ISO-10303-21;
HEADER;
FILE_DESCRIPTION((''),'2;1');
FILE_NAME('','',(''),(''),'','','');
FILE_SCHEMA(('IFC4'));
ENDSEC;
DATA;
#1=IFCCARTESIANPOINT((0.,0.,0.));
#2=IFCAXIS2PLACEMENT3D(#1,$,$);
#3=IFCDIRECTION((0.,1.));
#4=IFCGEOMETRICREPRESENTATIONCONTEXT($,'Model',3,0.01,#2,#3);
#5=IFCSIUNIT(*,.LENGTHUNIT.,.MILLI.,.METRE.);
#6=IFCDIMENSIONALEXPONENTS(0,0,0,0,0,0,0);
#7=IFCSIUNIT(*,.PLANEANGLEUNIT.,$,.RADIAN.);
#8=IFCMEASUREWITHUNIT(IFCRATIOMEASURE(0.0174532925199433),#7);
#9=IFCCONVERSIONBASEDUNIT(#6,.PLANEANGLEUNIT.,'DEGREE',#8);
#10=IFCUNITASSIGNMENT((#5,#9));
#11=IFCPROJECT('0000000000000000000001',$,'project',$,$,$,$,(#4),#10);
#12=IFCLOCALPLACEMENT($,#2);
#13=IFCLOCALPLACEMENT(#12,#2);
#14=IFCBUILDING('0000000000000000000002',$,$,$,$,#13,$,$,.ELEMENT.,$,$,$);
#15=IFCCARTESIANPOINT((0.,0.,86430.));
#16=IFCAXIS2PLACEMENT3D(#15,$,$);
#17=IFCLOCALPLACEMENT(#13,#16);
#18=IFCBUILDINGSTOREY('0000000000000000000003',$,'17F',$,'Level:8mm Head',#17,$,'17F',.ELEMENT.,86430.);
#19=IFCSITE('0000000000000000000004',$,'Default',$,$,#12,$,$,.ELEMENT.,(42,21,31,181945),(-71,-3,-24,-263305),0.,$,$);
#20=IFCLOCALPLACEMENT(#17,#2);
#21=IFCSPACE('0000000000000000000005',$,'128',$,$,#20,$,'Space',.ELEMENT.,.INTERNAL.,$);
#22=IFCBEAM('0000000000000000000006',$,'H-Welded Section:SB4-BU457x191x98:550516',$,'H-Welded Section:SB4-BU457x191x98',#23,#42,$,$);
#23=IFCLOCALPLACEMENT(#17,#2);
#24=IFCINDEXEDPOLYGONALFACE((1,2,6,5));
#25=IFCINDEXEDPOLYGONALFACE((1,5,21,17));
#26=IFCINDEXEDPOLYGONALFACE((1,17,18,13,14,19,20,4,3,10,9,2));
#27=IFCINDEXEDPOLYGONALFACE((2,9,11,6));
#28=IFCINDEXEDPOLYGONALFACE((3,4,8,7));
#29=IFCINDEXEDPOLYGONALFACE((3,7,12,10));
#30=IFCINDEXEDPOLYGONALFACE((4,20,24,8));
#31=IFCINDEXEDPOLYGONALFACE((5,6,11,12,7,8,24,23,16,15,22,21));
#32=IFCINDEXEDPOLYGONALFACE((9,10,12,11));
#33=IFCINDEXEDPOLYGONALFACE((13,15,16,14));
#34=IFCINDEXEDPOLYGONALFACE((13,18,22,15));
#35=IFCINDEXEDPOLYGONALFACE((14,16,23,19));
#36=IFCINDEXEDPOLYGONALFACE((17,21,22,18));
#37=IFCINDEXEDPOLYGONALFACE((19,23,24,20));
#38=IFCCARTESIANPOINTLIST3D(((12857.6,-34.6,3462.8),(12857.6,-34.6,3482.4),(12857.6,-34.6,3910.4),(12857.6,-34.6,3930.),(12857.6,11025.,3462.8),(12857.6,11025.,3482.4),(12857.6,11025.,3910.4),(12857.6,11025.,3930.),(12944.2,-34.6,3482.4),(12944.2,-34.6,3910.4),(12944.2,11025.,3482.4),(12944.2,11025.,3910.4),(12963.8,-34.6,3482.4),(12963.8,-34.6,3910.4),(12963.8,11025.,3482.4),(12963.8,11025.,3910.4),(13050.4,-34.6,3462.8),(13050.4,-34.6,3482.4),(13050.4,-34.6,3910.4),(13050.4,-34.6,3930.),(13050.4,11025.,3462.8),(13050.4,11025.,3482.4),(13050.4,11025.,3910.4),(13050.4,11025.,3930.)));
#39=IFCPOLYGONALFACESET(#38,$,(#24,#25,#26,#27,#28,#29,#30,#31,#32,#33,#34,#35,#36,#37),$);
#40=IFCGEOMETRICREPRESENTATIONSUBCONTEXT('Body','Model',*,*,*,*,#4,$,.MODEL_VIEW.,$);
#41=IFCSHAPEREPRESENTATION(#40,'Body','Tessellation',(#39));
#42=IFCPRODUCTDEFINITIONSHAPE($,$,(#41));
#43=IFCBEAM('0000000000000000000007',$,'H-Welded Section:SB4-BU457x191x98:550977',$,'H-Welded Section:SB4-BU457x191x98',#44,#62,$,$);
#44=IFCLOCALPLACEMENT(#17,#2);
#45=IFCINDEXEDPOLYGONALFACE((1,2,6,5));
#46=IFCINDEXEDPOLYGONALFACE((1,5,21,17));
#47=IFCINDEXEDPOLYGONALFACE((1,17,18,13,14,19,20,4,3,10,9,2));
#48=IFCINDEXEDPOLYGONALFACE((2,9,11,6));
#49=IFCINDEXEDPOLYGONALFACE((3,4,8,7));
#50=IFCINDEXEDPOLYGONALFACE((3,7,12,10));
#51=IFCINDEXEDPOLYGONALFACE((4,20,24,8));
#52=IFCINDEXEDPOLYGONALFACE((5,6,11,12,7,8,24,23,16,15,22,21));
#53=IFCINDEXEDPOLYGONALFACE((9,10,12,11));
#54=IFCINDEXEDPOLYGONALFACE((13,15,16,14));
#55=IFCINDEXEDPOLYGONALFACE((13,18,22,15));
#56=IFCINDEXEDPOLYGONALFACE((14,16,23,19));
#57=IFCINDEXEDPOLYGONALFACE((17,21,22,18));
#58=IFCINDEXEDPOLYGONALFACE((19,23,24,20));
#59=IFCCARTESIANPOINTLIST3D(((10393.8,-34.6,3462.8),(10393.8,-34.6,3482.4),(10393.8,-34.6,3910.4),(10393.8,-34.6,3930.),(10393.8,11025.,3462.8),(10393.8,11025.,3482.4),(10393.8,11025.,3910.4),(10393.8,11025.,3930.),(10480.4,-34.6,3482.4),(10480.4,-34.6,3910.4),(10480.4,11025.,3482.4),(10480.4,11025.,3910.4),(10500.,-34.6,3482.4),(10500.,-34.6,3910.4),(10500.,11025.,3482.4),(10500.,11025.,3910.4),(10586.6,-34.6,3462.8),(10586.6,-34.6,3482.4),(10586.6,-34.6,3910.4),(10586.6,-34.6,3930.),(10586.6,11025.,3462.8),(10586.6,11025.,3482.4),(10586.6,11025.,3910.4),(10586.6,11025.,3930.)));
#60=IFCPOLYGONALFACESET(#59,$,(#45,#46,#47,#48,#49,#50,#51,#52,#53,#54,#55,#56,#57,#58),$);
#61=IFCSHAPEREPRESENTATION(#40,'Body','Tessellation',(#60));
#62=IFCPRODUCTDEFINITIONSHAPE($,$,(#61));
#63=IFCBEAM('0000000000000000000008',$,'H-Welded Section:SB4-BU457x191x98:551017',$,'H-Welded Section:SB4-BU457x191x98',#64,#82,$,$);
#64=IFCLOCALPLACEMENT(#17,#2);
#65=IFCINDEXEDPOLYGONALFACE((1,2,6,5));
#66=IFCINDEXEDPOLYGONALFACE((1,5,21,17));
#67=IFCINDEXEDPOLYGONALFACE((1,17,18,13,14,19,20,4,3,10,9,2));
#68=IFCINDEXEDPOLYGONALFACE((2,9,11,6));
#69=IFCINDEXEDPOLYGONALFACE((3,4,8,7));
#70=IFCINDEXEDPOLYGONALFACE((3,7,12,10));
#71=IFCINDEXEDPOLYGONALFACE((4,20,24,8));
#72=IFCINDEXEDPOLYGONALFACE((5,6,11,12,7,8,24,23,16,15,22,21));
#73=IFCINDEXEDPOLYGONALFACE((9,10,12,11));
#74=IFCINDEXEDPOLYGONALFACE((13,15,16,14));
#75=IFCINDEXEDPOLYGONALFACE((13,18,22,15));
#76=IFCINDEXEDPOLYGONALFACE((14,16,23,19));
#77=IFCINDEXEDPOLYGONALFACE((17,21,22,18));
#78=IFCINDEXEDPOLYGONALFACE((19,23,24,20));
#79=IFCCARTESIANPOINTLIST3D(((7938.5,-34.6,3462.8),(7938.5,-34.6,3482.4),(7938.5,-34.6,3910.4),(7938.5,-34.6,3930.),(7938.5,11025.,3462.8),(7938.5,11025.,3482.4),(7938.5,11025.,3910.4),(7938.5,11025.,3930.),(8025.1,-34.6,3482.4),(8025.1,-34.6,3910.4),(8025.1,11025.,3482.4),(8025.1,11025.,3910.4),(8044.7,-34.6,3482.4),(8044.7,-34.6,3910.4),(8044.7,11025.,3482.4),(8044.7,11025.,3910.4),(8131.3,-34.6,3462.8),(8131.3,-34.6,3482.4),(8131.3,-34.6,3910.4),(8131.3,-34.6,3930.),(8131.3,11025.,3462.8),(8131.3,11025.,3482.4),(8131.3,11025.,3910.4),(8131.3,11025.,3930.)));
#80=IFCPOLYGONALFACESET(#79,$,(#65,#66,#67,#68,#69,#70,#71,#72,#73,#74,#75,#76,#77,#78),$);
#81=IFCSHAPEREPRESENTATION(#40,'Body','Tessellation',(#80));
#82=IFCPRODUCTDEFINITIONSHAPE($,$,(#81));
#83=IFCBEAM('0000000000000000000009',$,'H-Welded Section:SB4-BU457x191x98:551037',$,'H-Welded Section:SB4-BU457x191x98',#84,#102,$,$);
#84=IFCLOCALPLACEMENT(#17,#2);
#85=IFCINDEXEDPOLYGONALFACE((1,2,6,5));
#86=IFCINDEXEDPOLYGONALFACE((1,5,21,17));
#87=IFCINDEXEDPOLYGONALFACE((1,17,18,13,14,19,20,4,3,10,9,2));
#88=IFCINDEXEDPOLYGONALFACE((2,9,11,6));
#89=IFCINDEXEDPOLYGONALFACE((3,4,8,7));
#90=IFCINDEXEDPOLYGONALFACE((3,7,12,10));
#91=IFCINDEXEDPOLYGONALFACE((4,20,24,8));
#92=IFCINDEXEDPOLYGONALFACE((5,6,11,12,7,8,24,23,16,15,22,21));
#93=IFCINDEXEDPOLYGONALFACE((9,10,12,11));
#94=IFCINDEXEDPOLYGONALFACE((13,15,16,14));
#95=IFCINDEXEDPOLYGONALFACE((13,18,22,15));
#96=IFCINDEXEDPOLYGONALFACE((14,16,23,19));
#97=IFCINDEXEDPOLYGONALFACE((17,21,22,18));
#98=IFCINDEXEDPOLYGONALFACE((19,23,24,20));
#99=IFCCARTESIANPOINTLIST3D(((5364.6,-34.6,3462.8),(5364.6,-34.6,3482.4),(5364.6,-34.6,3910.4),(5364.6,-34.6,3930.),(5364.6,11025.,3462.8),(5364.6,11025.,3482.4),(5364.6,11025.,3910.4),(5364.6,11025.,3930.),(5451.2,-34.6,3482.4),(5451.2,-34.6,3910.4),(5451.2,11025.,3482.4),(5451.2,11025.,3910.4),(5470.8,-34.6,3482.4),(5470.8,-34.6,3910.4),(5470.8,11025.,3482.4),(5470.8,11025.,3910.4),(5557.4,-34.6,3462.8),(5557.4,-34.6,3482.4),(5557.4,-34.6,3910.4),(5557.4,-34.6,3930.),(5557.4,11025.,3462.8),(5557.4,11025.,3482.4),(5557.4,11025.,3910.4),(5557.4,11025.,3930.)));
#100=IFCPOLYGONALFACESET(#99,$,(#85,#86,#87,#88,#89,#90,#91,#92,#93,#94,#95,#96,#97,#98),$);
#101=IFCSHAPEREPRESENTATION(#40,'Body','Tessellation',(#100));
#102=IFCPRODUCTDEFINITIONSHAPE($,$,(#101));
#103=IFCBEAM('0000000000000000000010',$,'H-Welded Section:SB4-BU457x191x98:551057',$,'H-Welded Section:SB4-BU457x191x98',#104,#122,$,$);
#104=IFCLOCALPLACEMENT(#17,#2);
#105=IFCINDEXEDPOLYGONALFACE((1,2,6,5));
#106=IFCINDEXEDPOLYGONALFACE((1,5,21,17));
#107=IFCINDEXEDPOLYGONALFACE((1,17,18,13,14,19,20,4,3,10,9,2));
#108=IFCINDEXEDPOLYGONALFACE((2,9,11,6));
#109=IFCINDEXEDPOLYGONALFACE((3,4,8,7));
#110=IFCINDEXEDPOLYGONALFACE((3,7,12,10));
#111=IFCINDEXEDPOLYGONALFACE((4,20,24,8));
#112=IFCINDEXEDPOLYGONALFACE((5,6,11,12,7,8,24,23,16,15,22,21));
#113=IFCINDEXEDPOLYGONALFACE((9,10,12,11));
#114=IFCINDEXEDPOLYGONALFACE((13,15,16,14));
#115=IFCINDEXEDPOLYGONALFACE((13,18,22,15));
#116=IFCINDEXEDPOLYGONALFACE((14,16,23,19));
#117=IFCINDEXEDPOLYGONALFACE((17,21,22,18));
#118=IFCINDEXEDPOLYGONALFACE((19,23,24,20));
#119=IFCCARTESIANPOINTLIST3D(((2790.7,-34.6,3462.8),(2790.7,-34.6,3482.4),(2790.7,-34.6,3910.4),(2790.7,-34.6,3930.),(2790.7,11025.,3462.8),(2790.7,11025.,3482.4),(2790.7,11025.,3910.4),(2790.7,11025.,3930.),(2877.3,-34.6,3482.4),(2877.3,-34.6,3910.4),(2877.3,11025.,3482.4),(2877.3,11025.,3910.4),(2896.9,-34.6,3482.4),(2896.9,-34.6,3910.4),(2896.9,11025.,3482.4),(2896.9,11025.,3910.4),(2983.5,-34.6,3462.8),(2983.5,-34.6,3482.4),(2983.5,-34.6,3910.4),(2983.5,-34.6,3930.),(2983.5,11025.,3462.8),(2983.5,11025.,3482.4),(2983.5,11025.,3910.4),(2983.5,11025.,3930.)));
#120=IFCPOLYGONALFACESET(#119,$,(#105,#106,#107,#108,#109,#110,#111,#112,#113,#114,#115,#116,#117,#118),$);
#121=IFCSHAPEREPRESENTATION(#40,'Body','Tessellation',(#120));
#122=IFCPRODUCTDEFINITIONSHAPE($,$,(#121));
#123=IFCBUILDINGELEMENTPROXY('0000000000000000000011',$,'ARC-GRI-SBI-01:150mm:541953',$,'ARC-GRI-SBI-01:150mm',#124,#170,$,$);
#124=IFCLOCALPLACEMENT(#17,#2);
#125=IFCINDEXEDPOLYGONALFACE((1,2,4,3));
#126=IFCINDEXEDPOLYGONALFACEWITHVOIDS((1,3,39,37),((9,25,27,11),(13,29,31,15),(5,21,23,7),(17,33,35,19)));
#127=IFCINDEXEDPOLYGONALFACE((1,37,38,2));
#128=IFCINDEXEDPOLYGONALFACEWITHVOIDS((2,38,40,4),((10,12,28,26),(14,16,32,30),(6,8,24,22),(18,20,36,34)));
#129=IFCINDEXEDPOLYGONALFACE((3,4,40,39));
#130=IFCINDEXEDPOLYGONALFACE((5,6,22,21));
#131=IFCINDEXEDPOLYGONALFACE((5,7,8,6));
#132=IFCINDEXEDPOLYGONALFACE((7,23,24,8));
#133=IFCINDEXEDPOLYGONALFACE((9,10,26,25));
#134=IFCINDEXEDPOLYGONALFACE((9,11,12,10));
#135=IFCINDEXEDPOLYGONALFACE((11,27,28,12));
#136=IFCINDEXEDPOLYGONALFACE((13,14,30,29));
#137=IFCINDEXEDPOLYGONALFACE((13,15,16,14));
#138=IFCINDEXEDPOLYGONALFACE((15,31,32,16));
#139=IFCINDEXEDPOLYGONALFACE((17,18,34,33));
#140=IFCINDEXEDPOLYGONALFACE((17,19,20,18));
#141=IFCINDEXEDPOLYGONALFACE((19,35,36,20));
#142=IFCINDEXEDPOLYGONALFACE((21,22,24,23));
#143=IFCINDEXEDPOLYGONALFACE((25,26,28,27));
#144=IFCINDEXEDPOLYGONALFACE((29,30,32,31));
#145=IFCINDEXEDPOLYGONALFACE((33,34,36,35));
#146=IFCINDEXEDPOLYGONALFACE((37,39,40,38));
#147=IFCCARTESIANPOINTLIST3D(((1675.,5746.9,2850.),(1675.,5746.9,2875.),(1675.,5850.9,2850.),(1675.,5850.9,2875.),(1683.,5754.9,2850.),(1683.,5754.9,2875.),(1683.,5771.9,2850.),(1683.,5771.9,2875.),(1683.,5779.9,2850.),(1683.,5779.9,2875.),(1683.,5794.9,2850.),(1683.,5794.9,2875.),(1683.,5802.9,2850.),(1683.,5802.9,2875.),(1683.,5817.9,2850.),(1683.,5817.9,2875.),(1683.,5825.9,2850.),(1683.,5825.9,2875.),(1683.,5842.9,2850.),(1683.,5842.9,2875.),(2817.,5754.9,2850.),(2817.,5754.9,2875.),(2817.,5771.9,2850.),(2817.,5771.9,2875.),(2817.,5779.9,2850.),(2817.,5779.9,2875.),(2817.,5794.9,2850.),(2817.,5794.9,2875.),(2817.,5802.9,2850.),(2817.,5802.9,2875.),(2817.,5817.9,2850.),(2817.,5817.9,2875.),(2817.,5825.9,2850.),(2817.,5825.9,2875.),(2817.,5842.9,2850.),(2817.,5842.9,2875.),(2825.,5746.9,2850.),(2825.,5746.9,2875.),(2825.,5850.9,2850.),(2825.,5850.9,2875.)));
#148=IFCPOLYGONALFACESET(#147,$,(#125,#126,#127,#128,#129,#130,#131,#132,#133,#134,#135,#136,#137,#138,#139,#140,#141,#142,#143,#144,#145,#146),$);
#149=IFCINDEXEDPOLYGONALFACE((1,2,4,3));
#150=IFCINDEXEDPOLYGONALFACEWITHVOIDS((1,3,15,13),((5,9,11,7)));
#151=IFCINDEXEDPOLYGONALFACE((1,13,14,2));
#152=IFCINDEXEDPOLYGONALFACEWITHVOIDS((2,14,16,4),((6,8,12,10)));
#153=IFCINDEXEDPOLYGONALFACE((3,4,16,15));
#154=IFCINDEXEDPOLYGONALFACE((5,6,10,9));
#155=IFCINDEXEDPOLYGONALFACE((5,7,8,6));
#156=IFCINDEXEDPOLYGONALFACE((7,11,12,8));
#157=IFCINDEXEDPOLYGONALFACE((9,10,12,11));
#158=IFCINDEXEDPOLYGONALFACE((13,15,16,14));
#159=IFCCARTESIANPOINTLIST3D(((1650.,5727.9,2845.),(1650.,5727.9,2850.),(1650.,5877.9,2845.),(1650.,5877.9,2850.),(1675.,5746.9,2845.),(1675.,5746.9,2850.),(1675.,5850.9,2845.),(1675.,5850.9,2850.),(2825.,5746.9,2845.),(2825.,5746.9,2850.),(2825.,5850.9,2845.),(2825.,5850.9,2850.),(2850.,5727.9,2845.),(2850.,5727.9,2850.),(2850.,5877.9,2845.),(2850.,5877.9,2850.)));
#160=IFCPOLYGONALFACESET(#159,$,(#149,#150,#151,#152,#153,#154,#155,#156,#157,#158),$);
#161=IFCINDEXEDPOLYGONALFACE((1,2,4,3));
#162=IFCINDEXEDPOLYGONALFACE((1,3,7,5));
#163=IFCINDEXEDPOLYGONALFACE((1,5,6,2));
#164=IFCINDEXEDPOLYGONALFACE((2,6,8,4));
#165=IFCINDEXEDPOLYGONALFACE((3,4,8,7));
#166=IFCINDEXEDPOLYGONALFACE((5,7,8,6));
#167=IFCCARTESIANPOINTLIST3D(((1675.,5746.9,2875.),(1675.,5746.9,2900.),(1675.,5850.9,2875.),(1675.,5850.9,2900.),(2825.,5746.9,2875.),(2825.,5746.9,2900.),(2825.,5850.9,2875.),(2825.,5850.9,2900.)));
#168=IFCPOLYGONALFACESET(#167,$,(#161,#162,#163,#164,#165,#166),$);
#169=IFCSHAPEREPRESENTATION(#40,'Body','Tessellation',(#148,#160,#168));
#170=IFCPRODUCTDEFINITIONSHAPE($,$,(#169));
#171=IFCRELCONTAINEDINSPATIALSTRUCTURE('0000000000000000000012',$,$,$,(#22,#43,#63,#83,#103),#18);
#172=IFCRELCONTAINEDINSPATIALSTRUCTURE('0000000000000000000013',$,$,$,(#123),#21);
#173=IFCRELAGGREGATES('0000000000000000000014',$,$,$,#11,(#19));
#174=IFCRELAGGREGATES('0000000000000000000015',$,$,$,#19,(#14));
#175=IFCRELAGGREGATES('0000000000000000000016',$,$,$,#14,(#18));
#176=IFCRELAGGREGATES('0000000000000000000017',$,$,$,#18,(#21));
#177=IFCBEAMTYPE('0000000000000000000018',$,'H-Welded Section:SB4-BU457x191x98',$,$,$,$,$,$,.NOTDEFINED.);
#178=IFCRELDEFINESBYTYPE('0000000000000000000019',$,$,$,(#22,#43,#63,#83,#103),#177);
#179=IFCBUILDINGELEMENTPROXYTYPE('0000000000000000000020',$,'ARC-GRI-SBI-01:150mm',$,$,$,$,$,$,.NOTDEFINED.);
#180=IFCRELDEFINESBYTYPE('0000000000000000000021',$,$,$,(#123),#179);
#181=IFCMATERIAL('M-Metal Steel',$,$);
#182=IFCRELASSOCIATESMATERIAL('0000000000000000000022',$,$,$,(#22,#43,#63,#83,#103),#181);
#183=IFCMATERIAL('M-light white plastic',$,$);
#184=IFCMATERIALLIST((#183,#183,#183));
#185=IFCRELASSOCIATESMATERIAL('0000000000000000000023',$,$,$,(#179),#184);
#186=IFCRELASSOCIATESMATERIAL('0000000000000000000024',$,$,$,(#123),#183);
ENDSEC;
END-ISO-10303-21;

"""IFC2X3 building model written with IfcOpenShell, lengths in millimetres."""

from ifc_helpers import new_model, entity, si_unit, converted_unit, direction, frame, frame_2d, origin, origin_2d_with_axis, place, context, subcontext, project, spatial, polyline, rectangle, i_section, outline, extrude, source, transform, mapped, material, material_list, type_object, type_shapes, element, save


model = new_model("IFC2X3")

# Units and contexts
model_context = context("Model", 3, precision=0.01, world=origin(), true_north=direction((0.0, 1.0)))
body_context = subcontext(model_context, "Body", "Model", "MODEL_VIEW")
ifc_project = project(units=[si_unit("LENGTHUNIT", "METRE", prefix="MILLI"), converted_unit("PLANEANGLEUNIT", "DEGREE", entity("IfcRatioMeasure", 0.0174532925199433), si_unit("PLANEANGLEUNIT", "RADIAN"), dimensions=[0, 0, 0, 0, 0, 0, 0])], contexts=[model_context])

# Site, building, storey
site_placement = place(None, origin())
site = spatial("IfcSite", under=ifc_project, at=site_placement, Name="Default", CompositionType="ELEMENT", RefLatitude=(42, 21, 31, 181945), RefLongitude=(-71, -3, -24, -263305), RefElevation=0.0)
building_placement = place(site_placement, origin())
building = spatial("IfcBuilding", under=site, at=building_placement, CompositionType="ELEMENT")
storey_placement = place(building_placement, frame((0.0, 0.0, 86430.0)))
storey = spatial("IfcBuildingStorey", under=building, at=storey_placement, Name="17F", ObjectType="Level:8mm Head", LongName="17F", CompositionType="ELEMENT", Elevation=86430.0)

# Beams
ifc_material_1 = material(Name="M-Metal Steel")
beam_type = type_object("IfcBeamType", Name="H-Welded Section:SB4-BU457x191x98", PredefinedType="NOTDEFINED")
beam_1_placement = place(storey_placement, frame((12954.0, 11025.0, 0.0), z_axis=(0.0, 0.0, 1.0), x_axis=(0.0, -1.0, 0.0)))
element("IfcBeam", 1, at=beam_1_placement, inside=storey, type_object=beam_type, material=ifc_material_1, Name="H-Welded Section:SB4-BU457x191x98:550516", ObjectType="H-Welded Section:SB4-BU457x191x98", context=body_context, shape_type="SweptSolid", body=[
    extrude(i_section(OverallWidth=192.8, OverallDepth=467.2, WebThickness=19.6, FlangeThickness=19.6, at=frame_2d((0.0, 0.0), x_axis=(0.0, 1.0))), frame((0.0, 0.0, 3696.4), z_axis=(1.0, 0.0, 0.0), x_axis=(0.0, 0.0, -1.0)), (0.0, 0.0, 1.0), 11059.6),
])
beam_2_placement = place(storey_placement, frame((10490.2, 11025.0, 0.0), z_axis=(0.0, 0.0, 1.0), x_axis=(0.0, -1.0, 0.0)))
element("IfcBeam", 2, at=beam_2_placement, inside=storey, type_object=beam_type, material=ifc_material_1, Name="H-Welded Section:SB4-BU457x191x98:550977", ObjectType="H-Welded Section:SB4-BU457x191x98", context=body_context, shape_type="SweptSolid", body=[
    extrude(i_section(OverallWidth=192.8, OverallDepth=467.2, WebThickness=19.6, FlangeThickness=19.6, at=frame_2d((0.0, 0.0), x_axis=(0.0, 1.0))), frame((0.0, 0.0, 3696.4), z_axis=(1.0, 0.0, 0.0), x_axis=(0.0, 0.0, -1.0)), (0.0, 0.0, 1.0), 11059.6),
])
beam_3_placement = place(storey_placement, frame((8034.9, 11025.0, 0.0), z_axis=(0.0, 0.0, 1.0), x_axis=(0.0, -1.0, 0.0)))
element("IfcBeam", 3, at=beam_3_placement, inside=storey, type_object=beam_type, material=ifc_material_1, Name="H-Welded Section:SB4-BU457x191x98:551017", ObjectType="H-Welded Section:SB4-BU457x191x98", context=body_context, shape_type="SweptSolid", body=[
    extrude(i_section(OverallWidth=192.8, OverallDepth=467.2, WebThickness=19.6, FlangeThickness=19.6, at=frame_2d((0.0, 0.0), x_axis=(0.0, 1.0))), frame((0.0, 0.0, 3696.4), z_axis=(1.0, 0.0, 0.0), x_axis=(0.0, 0.0, -1.0)), (0.0, 0.0, 1.0), 11059.6),
])
beam_4_placement = place(storey_placement, frame((5461.0, 11025.0, 0.0), z_axis=(0.0, 0.0, 1.0), x_axis=(0.0, -1.0, 0.0)))
element("IfcBeam", 4, at=beam_4_placement, inside=storey, type_object=beam_type, material=ifc_material_1, Name="H-Welded Section:SB4-BU457x191x98:551037", ObjectType="H-Welded Section:SB4-BU457x191x98", context=body_context, shape_type="SweptSolid", body=[
    extrude(i_section(OverallWidth=192.8, OverallDepth=467.2, WebThickness=19.6, FlangeThickness=19.6, at=frame_2d((0.0, 0.0), x_axis=(0.0, 1.0))), frame((0.0, 0.0, 3696.4), z_axis=(1.0, 0.0, 0.0), x_axis=(0.0, 0.0, -1.0)), (0.0, 0.0, 1.0), 11059.6),
])
beam_5_placement = place(storey_placement, frame((2887.1, 11025.0, 0.0), z_axis=(0.0, 0.0, 1.0), x_axis=(0.0, -1.0, 0.0)))
element("IfcBeam", 5, at=beam_5_placement, inside=storey, type_object=beam_type, material=ifc_material_1, Name="H-Welded Section:SB4-BU457x191x98:551057", ObjectType="H-Welded Section:SB4-BU457x191x98", context=body_context, shape_type="SweptSolid", body=[
    extrude(i_section(OverallWidth=192.8, OverallDepth=467.2, WebThickness=19.6, FlangeThickness=19.6, at=frame_2d((0.0, 0.0), x_axis=(0.0, 1.0))), frame((0.0, 0.0, 3696.4), z_axis=(1.0, 0.0, 0.0), x_axis=(0.0, 0.0, -1.0)), (0.0, 0.0, 1.0), 11059.6),
])

# Shared definitions
space_placement = place(storey_placement, origin())
space = spatial("IfcSpace", under=storey, at=space_placement, Name="128", LongName="Space", CompositionType="ELEMENT", InteriorOrExteriorSpace="INTERNAL")

# Building element proxy
ifc_material_2 = material(Name="M-light white plastic")
ifc_material_list = material_list([ifc_material_2, ifc_material_2, ifc_material_2])
building_element_proxy_type = type_object("IfcBuildingElementProxyType", Name="ARC-GRI-SBI-01:150mm", PredefinedType="NOTDEFINED", material=ifc_material_list)
shared_shape = source(origin(), body_context, "Body", "SweptSolid", [
    extrude(outline(polyline([(-575.0, -52.0), (575.0, -52.0), (575.0, 52.0), (-575.0, 52.0), (-575.0, -52.0)]), holes=[polyline([(-567.0, -44.0), (-567.0, -27.0), (567.0, -27.0), (567.0, -44.0), (-567.0, -44.0)]), polyline([(567.0, -4.0), (567.0, -19.0), (-567.0, -19.0), (-567.0, -4.0), (567.0, -4.0)]), polyline([(-567.0, 44.0), (567.0, 44.0), (567.0, 27.0), (-567.0, 27.0), (-567.0, 44.0)]), polyline([(567.0, 4.0), (-567.0, 4.0), (-567.0, 19.0), (567.0, 19.0), (567.0, 4.0)])]), frame((425.0, 4.0, 4000.0), z_axis=(0.0, 0.0, 1.0), x_axis=(-1.0, 0.0, 0.0)), (0.0, 0.0, 1.0), 25.0),
    extrude(outline(polyline([(-600.0, -75.0), (600.0, -75.0), (600.0, 75.0), (-600.0, 75.0), (-600.0, -75.0)]), holes=[polyline([(-575.0, -56.0), (-575.0, 48.0), (575.0, 48.0), (575.0, -56.0), (-575.0, -56.0)])]), frame((425.0, 0.0, 3995.0), z_axis=(0.0, 0.0, 1.0), x_axis=(-1.0, 0.0, 0.0)), (0.0, 0.0, 1.0), 5.0),
    extrude(rectangle(XDim=1150.0, YDim=104.0, at=origin_2d_with_axis()), frame((425.0, 4.0, 4025.0), z_axis=(0.0, 0.0, 1.0), x_axis=(-1.0, 0.0, 0.0)), (0.0, 0.0, 1.0), 25.0),
])
type_shapes(building_element_proxy_type, [shared_shape])
for number, where, z_axis, x_axis, name in (
    (6, (2675.0, 5802.9, -1150.0), (0.0, 0.0, 1.0), (-1.0, 0.0, 0.0), "ARC-GRI-SBI-01:150mm:541953"),
):
    element("IfcBuildingElementProxy", number, at=place(space_placement, frame(where, z_axis=z_axis, x_axis=x_axis)), inside=space, type_object=building_element_proxy_type, material=ifc_material_2, Name=name, ObjectType="ARC-GRI-SBI-01:150mm", context=body_context, shape_type="MappedRepresentation", body=[
        mapped(shared_shape, transform((0.0, 0.0, 0.0), scale=1.0)),
    ])

save(model, "model.ifc")
